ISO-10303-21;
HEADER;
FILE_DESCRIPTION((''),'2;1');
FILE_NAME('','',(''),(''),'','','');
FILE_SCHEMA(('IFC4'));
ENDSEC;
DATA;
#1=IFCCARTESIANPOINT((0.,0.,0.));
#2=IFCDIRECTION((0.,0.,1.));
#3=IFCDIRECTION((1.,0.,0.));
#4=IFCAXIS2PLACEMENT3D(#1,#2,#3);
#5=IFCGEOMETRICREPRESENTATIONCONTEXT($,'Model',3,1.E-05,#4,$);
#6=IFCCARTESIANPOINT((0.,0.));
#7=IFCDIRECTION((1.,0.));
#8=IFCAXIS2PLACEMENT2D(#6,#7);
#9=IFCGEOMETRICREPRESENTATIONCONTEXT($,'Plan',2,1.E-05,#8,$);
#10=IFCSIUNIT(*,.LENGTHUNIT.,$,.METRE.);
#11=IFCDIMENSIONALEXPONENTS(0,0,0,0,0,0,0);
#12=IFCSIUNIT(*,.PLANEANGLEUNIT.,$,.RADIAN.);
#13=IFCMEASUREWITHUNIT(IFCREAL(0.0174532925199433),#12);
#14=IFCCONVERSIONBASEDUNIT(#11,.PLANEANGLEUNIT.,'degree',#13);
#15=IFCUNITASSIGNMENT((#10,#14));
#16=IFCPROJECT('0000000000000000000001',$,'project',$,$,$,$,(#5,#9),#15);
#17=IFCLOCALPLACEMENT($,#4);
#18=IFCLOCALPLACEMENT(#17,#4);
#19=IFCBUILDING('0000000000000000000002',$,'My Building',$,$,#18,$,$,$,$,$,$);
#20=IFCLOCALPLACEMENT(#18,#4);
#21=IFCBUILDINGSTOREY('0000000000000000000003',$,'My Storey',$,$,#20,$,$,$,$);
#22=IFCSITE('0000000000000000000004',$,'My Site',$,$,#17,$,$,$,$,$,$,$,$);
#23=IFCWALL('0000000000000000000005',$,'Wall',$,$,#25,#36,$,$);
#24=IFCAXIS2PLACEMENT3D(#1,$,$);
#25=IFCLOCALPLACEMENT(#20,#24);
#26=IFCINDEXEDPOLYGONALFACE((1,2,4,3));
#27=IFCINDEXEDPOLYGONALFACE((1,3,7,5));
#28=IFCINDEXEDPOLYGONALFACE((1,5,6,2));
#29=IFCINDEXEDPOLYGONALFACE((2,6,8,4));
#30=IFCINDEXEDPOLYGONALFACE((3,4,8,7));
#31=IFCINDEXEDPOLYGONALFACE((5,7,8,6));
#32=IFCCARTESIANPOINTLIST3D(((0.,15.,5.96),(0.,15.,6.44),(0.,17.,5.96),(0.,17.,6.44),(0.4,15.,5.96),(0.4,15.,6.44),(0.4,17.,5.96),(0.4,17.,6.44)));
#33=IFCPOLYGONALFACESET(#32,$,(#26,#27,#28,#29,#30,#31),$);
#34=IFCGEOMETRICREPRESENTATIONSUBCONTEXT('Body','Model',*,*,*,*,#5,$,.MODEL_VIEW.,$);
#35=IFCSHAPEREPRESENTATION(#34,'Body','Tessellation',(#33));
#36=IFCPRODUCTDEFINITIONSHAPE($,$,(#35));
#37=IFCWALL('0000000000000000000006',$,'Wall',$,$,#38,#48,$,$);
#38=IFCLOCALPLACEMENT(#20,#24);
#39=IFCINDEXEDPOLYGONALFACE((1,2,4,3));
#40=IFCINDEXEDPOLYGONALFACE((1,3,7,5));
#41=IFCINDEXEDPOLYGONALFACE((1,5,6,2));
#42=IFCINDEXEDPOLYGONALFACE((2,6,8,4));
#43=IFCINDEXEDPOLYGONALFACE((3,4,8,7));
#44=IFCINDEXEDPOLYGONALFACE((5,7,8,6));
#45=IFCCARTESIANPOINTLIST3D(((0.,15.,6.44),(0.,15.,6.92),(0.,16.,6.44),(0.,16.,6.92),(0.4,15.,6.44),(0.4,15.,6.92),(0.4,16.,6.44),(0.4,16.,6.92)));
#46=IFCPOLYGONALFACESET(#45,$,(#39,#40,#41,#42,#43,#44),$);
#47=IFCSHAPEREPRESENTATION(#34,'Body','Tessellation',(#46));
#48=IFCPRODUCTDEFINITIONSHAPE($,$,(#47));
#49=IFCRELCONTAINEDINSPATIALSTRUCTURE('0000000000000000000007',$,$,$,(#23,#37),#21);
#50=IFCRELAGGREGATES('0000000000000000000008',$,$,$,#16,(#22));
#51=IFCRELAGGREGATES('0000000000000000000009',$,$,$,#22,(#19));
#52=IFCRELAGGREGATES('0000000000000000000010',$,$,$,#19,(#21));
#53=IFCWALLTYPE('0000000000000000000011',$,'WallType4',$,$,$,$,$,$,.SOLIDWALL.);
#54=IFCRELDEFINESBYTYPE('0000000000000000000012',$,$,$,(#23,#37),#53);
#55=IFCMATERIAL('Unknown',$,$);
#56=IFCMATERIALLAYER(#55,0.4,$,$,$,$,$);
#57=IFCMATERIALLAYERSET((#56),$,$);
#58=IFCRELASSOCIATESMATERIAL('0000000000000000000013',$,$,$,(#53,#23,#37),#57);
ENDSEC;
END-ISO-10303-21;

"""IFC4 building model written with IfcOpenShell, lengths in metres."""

from ifc_helpers import new_model, entity, si_unit, converted_unit, frame, origin_with_axes, origin_2d_with_axis, place, context, subcontext, project, spatial, indexed_curve, outline, extrude, material, layer, layer_set, layer_usage, type_object, element, save


model = new_model("IFC4")

# Units and contexts
model_context = context("Model", 3, precision=1e-05, world=origin_with_axes())
plan_context = context("Plan", 2, precision=1e-05, world=origin_2d_with_axis())
body_context_1 = subcontext(model_context, "Body", "Model", "MODEL_VIEW")
ifc_project = project(units=[si_unit("LENGTHUNIT", "METRE"), converted_unit("PLANEANGLEUNIT", "degree", entity("IfcReal", 0.0174532925199433), si_unit("PLANEANGLEUNIT", "RADIAN"), dimensions=[0, 0, 0, 0, 0, 0, 0])], contexts=[model_context, plan_context])

# Site, building, storey
site_placement = place(None, origin_with_axes())
site = spatial("IfcSite", under=ifc_project, at=site_placement, Name="My Site")
building_placement = place(site_placement, origin_with_axes())
building = spatial("IfcBuilding", under=site, at=building_placement, Name="My Building")
storey_placement = place(building_placement, origin_with_axes())
storey = spatial("IfcBuildingStorey", under=building, at=storey_placement, Name="My Storey")

# Shared definitions
ifc_material = material(Name="Unknown")

# Shared definitions
ifc_layer_1 = layer(ifc_material, 0.4)
ifc_layer_set_1 = layer_set([ifc_layer_1])
wall_type_1 = type_object("IfcWallType", Name="WallType4", PredefinedType="SOLIDWALL", material=ifc_layer_set_1)

# Walls
ifc_layer_usage_1 = layer_usage(ifc_layer_set_1, "AXIS2", "POSITIVE", 0.0)
wall_1_placement = place(storey_placement, frame((0.4, 15.0, 5.96), z_axis=(0.0, 0.0, 1.0), x_axis=(0.0, 1.0, 0.0)))
element("IfcWall", 1, at=wall_1_placement, inside=storey, type_object=wall_type_1, material=ifc_layer_usage_1, Name="Wall", context=body_context_1, shape_type="SweptSolid", body=[
    extrude(outline(indexed_curve([(0.0, 0.0), (0.0, 0.4), (2.0, 0.4), (2.0, 0.0), (0.0, 0.0)], self_intersect=False)), origin_with_axes(), (0.0, 0.0, 1.0), 0.48),
])
ifc_layer_usage_2 = layer_usage(ifc_layer_set_1, "AXIS2", "POSITIVE", 0.0)
wall_2_placement = place(storey_placement, frame((0.4, 15.0, 6.44), z_axis=(0.0, 0.0, 1.0), x_axis=(0.0, 1.0, 0.0)))
element("IfcWall", 2, at=wall_2_placement, inside=storey, type_object=wall_type_1, material=ifc_layer_usage_2, Name="Wall", context=body_context_1, shape_type="SweptSolid", body=[
    extrude(outline(indexed_curve([(0.0, 0.0), (0.0, 0.4), (1.0, 0.4), (1.0, 0.0), (0.0, 0.0)], self_intersect=False)), origin_with_axes(), (0.0, 0.0, 1.0), 0.48),
])

save(model, "model.ifc")
